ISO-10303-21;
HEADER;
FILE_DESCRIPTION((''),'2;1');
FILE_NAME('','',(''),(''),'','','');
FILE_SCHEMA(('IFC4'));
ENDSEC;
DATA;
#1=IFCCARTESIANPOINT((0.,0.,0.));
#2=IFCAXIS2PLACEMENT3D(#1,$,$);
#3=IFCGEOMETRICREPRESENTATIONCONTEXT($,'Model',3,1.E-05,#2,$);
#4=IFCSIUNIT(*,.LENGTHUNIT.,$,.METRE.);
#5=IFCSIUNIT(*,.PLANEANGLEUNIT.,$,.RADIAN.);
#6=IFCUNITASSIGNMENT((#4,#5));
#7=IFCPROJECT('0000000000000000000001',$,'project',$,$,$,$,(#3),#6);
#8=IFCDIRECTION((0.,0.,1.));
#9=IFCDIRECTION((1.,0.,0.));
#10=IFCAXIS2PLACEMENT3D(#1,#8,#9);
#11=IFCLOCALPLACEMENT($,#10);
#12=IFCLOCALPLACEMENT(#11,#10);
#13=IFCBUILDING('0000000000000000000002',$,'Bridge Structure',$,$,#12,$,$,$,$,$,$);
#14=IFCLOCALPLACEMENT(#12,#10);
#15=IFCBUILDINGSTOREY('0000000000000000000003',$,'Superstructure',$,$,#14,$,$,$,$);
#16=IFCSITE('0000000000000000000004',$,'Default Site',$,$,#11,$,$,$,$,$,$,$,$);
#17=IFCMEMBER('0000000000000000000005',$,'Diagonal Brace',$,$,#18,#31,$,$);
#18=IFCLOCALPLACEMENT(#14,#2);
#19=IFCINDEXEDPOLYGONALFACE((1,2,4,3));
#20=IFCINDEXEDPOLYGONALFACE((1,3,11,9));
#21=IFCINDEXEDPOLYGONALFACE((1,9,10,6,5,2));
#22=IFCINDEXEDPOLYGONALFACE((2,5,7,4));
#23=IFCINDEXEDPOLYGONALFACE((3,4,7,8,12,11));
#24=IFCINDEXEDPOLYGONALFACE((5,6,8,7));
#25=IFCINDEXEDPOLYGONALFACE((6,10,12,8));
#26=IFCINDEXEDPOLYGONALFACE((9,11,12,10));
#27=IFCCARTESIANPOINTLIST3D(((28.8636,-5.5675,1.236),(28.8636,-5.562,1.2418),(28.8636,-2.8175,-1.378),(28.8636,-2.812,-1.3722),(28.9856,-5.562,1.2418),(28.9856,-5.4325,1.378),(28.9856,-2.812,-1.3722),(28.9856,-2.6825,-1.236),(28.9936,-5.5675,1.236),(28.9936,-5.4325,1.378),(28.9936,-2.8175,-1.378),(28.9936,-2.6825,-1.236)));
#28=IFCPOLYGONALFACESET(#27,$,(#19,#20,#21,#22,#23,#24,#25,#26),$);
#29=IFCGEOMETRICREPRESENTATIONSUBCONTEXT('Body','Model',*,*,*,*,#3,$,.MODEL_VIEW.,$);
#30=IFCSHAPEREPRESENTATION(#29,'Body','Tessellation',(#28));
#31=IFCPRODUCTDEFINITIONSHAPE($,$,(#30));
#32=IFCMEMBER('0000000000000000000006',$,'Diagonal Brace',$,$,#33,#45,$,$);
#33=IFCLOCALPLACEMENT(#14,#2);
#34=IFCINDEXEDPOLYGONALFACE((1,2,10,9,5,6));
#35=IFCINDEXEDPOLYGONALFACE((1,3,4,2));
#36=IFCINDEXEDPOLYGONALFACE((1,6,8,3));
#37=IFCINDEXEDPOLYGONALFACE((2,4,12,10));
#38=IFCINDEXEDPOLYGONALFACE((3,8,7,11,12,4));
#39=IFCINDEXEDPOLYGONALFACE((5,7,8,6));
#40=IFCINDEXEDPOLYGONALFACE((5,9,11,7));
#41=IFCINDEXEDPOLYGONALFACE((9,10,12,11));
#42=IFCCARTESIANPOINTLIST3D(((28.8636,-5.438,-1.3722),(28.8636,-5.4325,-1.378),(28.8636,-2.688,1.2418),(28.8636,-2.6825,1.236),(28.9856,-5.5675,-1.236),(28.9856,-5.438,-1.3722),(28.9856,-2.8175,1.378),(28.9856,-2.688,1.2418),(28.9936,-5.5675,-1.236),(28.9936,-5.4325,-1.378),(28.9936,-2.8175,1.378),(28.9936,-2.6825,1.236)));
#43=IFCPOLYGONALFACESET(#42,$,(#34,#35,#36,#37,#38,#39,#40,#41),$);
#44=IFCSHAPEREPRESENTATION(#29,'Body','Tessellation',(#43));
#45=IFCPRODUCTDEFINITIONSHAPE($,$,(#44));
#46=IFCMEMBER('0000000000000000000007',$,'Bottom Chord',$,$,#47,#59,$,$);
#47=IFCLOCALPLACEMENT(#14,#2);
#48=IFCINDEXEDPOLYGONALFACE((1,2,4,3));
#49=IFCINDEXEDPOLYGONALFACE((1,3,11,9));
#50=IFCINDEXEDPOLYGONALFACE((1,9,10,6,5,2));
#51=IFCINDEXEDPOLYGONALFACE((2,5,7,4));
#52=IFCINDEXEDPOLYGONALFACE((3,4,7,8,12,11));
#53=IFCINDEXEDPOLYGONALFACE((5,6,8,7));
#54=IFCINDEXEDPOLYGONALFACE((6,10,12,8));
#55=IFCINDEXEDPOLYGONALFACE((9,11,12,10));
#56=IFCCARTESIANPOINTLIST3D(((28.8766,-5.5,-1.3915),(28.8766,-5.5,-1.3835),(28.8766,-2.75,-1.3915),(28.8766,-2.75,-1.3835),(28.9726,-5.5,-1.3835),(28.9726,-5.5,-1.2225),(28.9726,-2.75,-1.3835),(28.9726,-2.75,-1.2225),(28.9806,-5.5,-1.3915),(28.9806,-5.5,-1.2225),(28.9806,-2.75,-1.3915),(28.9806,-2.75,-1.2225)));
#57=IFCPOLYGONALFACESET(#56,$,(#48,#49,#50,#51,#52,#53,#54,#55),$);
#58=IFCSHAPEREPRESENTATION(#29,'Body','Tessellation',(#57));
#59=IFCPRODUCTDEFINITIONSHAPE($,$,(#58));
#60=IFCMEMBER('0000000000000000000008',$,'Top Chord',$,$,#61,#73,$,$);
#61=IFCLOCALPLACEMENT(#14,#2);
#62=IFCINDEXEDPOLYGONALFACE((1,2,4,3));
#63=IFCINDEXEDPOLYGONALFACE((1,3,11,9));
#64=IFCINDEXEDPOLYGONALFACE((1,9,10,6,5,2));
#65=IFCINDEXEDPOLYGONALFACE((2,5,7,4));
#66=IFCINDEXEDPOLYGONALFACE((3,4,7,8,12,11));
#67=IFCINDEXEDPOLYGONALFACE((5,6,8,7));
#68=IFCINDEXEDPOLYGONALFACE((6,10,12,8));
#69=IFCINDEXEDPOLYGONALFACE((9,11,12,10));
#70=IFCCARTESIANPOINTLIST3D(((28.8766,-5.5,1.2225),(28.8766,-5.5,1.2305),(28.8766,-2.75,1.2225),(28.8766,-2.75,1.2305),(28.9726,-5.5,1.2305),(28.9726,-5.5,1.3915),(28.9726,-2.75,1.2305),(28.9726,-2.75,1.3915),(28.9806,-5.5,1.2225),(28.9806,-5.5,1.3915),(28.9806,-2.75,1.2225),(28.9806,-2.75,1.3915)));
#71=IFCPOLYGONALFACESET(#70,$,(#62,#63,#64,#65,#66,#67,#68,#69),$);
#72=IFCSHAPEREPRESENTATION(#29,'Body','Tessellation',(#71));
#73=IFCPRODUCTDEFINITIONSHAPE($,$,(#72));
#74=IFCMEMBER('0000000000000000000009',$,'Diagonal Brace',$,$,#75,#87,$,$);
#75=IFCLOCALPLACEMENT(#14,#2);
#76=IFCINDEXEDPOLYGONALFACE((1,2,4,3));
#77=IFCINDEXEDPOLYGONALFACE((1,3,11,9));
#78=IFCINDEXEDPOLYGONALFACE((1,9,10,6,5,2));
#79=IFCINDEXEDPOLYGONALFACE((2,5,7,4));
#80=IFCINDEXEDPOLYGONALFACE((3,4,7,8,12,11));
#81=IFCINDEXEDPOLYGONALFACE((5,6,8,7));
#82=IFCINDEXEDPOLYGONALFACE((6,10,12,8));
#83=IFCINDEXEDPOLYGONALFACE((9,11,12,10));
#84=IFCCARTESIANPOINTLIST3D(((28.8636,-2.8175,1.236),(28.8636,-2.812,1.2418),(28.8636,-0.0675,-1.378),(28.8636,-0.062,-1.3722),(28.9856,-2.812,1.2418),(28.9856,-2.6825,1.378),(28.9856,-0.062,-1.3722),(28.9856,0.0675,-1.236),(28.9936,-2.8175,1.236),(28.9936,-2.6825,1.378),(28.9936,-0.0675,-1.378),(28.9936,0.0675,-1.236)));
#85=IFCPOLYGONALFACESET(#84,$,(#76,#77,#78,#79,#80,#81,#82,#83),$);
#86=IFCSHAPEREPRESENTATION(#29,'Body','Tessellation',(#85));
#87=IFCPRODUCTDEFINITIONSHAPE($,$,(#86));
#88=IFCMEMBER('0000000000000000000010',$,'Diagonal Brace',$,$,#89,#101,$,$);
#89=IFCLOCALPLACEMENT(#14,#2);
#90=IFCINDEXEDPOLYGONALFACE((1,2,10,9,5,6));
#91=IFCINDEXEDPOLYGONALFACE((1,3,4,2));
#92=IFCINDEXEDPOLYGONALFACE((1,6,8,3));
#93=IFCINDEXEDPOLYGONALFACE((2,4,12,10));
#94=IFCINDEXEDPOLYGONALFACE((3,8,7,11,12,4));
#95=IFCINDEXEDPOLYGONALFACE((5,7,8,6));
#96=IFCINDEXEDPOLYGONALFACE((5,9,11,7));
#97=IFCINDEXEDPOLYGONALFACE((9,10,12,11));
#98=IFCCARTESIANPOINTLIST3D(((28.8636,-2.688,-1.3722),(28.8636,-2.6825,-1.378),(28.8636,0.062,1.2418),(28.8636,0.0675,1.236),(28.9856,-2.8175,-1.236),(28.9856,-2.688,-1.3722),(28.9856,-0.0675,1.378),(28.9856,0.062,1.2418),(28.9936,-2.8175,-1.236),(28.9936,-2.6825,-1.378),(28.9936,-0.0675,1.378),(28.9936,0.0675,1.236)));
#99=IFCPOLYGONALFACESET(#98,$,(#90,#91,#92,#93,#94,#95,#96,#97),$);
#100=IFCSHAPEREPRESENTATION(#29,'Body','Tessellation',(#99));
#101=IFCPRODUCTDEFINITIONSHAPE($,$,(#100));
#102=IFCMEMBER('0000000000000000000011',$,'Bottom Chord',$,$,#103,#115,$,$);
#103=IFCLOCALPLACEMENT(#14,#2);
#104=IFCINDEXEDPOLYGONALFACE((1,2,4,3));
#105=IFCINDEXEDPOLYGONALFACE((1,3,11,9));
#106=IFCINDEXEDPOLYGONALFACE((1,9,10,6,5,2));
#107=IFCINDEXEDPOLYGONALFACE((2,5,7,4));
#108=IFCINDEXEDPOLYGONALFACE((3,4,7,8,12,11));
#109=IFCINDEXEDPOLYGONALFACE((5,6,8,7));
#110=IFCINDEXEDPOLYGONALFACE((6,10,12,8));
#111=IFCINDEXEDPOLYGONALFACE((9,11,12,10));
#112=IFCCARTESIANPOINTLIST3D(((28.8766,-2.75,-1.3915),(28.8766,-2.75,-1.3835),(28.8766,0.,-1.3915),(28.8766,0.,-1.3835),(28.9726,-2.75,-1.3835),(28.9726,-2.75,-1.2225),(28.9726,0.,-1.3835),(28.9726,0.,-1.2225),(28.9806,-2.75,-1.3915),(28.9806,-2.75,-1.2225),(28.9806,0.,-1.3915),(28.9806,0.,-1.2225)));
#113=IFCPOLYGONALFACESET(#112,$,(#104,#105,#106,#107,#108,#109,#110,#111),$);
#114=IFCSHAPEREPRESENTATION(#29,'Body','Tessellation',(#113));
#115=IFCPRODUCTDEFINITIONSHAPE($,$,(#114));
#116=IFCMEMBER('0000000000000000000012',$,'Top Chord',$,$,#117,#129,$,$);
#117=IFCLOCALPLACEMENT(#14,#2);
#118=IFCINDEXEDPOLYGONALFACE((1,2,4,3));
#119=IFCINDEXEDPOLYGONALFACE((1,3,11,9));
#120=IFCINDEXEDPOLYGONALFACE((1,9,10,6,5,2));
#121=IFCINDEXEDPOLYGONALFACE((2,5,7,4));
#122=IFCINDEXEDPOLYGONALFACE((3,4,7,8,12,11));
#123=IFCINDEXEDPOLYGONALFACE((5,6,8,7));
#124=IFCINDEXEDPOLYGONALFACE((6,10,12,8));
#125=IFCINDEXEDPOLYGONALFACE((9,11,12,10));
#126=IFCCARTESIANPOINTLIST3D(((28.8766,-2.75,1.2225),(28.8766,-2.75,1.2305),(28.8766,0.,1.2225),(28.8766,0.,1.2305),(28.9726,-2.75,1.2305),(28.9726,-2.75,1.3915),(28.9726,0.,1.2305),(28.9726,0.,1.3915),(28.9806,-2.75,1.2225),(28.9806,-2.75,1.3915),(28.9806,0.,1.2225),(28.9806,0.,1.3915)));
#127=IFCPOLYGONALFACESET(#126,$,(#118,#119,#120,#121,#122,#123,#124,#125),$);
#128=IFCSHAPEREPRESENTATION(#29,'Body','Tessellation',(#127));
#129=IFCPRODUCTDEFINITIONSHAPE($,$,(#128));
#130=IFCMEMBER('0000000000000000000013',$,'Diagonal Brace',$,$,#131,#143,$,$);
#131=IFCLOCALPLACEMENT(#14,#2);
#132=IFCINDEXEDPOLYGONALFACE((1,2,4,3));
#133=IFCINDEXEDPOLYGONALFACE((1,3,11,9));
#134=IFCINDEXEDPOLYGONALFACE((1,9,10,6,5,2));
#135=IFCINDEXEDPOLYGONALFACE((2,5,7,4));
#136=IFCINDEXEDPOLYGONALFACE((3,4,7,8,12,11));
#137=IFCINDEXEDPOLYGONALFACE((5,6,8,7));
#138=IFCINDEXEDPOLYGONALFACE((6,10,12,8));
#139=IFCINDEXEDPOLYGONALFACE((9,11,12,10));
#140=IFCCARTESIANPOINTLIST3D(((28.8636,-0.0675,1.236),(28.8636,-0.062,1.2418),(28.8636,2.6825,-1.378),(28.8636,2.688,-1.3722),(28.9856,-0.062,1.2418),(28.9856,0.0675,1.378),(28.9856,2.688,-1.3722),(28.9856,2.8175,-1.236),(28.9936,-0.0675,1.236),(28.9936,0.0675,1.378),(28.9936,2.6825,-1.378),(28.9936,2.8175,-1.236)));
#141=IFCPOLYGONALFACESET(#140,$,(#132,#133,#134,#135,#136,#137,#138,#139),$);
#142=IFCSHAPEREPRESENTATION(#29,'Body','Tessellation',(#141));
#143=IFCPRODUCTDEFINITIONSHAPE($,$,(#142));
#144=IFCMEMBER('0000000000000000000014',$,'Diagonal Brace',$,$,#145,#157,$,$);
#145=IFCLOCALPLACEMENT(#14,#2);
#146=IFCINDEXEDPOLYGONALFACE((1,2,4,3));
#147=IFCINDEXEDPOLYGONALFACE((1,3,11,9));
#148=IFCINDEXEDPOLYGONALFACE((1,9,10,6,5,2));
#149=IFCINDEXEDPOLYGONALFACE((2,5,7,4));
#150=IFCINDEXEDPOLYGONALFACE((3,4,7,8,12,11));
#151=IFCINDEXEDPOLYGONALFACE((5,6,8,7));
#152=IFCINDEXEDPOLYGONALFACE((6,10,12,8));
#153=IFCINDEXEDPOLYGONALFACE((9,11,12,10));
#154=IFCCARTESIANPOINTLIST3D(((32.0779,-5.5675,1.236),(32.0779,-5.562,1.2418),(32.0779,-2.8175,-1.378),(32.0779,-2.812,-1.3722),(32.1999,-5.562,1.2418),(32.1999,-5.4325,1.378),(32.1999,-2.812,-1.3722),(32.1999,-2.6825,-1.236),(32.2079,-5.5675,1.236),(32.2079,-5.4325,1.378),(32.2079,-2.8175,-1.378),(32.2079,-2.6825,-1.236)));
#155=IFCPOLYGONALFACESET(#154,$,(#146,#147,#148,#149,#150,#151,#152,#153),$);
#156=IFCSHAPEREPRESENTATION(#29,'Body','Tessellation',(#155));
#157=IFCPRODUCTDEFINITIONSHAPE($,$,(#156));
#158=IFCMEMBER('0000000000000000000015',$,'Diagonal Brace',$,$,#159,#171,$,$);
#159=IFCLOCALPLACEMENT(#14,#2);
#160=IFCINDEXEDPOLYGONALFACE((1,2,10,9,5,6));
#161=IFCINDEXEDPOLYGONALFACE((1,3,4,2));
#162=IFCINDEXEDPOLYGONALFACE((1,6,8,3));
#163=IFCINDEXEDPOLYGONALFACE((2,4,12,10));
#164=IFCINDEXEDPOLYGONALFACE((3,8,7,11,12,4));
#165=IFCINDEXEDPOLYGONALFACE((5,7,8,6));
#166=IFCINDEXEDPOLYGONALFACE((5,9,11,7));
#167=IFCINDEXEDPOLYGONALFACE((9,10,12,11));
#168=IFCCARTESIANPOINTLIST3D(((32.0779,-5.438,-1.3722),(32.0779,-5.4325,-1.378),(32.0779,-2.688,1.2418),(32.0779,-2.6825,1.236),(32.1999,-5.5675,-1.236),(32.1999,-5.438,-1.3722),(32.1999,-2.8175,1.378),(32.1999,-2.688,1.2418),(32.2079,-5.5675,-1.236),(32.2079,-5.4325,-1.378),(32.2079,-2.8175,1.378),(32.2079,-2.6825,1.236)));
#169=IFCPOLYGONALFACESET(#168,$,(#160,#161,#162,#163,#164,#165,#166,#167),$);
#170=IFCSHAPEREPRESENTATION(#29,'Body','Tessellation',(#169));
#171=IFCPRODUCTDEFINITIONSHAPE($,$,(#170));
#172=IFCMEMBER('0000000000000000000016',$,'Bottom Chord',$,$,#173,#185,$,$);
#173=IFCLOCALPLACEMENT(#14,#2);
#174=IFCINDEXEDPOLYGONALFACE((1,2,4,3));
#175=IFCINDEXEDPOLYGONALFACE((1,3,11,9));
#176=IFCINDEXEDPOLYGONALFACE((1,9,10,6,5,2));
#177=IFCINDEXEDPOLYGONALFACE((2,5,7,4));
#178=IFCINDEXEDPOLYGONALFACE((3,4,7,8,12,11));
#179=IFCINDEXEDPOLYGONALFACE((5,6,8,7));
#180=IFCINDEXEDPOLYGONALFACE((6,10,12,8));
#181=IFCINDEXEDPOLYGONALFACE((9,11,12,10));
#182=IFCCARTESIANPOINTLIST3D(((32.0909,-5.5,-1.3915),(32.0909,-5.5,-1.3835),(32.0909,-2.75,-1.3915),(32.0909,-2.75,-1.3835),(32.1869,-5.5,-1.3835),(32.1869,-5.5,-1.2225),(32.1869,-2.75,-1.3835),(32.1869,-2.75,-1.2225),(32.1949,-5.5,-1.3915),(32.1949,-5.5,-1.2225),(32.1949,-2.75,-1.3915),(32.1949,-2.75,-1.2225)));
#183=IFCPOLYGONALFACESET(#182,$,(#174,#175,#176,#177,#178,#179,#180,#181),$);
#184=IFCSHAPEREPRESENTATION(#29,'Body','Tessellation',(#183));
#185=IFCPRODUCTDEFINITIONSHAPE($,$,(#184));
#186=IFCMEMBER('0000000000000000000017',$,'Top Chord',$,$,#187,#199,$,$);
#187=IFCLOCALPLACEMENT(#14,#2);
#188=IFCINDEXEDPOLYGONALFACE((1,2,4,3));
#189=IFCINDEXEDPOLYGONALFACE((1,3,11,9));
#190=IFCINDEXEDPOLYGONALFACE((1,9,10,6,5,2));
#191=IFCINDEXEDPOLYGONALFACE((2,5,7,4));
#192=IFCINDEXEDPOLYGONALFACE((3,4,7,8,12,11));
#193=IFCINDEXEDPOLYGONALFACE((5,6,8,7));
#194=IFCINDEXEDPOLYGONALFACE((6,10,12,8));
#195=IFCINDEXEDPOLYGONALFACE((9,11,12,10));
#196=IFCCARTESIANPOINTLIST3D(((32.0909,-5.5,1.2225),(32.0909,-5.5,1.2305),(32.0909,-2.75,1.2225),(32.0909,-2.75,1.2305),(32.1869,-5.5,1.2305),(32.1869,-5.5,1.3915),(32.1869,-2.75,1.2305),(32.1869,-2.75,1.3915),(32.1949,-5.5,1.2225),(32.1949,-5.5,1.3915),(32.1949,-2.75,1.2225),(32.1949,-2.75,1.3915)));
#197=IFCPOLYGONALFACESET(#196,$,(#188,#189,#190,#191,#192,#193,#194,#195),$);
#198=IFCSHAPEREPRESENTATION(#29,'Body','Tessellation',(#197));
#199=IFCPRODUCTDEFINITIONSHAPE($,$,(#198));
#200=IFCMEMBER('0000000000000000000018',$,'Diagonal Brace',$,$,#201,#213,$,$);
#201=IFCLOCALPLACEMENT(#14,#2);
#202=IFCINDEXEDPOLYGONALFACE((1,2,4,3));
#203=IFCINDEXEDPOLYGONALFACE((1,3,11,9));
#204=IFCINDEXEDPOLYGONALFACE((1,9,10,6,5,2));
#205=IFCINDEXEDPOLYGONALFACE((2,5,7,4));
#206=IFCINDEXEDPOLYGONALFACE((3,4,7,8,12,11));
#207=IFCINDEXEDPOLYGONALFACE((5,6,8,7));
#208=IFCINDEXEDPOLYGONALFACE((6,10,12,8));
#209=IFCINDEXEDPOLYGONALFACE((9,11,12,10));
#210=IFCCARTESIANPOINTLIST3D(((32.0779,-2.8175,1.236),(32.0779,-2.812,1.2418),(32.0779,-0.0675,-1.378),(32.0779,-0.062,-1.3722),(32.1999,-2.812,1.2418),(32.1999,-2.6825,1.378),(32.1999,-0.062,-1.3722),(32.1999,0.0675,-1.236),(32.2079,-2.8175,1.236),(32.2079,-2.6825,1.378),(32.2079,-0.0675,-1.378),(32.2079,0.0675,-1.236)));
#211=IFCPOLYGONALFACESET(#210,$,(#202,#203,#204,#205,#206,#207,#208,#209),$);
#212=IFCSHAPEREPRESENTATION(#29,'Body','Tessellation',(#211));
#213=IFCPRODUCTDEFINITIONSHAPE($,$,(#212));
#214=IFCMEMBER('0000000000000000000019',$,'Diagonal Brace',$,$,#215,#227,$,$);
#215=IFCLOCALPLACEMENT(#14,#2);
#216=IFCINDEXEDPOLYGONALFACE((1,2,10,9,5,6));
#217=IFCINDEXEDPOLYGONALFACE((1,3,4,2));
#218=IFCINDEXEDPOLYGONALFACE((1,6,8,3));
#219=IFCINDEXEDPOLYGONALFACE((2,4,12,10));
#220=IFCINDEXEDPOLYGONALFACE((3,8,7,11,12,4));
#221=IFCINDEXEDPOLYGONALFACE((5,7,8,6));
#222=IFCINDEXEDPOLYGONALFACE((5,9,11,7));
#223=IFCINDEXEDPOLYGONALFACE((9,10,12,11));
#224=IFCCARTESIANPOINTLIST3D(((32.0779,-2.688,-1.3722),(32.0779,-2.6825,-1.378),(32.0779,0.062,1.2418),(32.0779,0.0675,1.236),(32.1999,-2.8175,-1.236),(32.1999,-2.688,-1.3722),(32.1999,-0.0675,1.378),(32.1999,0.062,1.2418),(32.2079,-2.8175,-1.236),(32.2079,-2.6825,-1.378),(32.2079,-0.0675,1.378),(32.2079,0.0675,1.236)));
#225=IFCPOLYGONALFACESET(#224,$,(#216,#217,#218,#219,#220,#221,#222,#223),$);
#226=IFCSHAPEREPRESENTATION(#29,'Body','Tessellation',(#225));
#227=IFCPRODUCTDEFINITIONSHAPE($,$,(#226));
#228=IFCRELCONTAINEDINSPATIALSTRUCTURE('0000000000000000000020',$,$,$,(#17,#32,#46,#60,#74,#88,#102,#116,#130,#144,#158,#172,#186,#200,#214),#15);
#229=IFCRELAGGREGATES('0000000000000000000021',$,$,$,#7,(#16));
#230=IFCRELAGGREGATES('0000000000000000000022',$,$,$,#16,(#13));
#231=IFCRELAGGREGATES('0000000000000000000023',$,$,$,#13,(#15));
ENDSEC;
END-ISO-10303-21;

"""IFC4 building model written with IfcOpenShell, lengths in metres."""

from ifc_helpers import new_model, si_unit, frame, origin, origin_with_axes, origin_2d_with_axis, place, context, subcontext, project, spatial, l_section, extrude, element, save


model = new_model("IFC4")

# Units and contexts
model_context = context("Model", 3, precision=1e-05, world=origin())
body_context = subcontext(model_context, "Body", "Model", "MODEL_VIEW")
ifc_project = project(units=[si_unit("LENGTHUNIT", "METRE"), si_unit("PLANEANGLEUNIT", "RADIAN")], contexts=[model_context])

# Site, building, storey
site_placement = place(None, origin_with_axes())
site = spatial("IfcSite", under=ifc_project, at=site_placement, Name="Default Site")
building_placement = place(site_placement, origin_with_axes())
building = spatial("IfcBuilding", under=site, at=building_placement, Name="Bridge Structure")
storey_placement = place(building_placement, origin_with_axes())
storey = spatial("IfcBuildingStorey", under=building, at=storey_placement, Name="Superstructure")

# Members
for number, where, z_axis, x_axis, name in (
    (1, (28.9286, -5.5, 1.307), (0.0, 0.724802, -0.688957), (-1.0, 0.0, 0.0), "Diagonal Brace"),
    (2, (28.9286, -5.5, -1.307), (0.0, 0.724802, 0.688957), (-1.0, 0.0, 0.0), "Diagonal Brace"),
):
    element("IfcMember", number, at=place(storey_placement, frame(where, z_axis=z_axis, x_axis=x_axis)), inside=storey, Name=name, context=body_context, shape_type="SweptSolid", body=[
        extrude(l_section(Depth=0.196, Width=0.13, Thickness=0.008, at=origin_2d_with_axis()), origin_with_axes(), (0.0, 0.0, 1.0), 3.7941),
    ])
for number, where, z_axis, x_axis, name in (
    (3, (28.9286, -5.5, -1.307), (0.0, 1.0, 0.0), (-1.0, 0.0, 0.0), "Bottom Chord"),
    (4, (28.9286, -5.5, 1.307), (0.0, 1.0, 0.0), (-1.0, 0.0, 0.0), "Top Chord"),
):
    element("IfcMember", number, at=place(storey_placement, frame(where, z_axis=z_axis, x_axis=x_axis)), inside=storey, Name=name, context=body_context, shape_type="SweptSolid", body=[
        extrude(l_section(Depth=0.169, Width=0.104, Thickness=0.008, at=origin_2d_with_axis()), origin_with_axes(), (0.0, 0.0, 1.0), 2.75),
    ])
for number, where, z_axis, x_axis, name in (
    (5, (28.9286, -2.75, 1.307), (0.0, 0.724802, -0.688957), (-1.0, 0.0, 0.0), "Diagonal Brace"),
    (6, (28.9286, -2.75, -1.307), (0.0, 0.724802, 0.688957), (-1.0, 0.0, 0.0), "Diagonal Brace"),
):
    element("IfcMember", number, at=place(storey_placement, frame(where, z_axis=z_axis, x_axis=x_axis)), inside=storey, Name=name, context=body_context, shape_type="SweptSolid", body=[
        extrude(l_section(Depth=0.196, Width=0.13, Thickness=0.008, at=origin_2d_with_axis()), origin_with_axes(), (0.0, 0.0, 1.0), 3.7941),
    ])
for number, where, z_axis, x_axis, name in (
    (7, (28.9286, -2.75, -1.307), (0.0, 1.0, 0.0), (-1.0, 0.0, 0.0), "Bottom Chord"),
    (8, (28.9286, -2.75, 1.307), (0.0, 1.0, 0.0), (-1.0, 0.0, 0.0), "Top Chord"),
):
    element("IfcMember", number, at=place(storey_placement, frame(where, z_axis=z_axis, x_axis=x_axis)), inside=storey, Name=name, context=body_context, shape_type="SweptSolid", body=[
        extrude(l_section(Depth=0.169, Width=0.104, Thickness=0.008, at=origin_2d_with_axis()), origin_with_axes(), (0.0, 0.0, 1.0), 2.75),
    ])
for number, where, z_axis, x_axis, name in (
    (9, (28.9286, 0.0, 1.307), (0.0, 0.724802, -0.688957), (-1.0, 0.0, 0.0), "Diagonal Brace"),
    (10, (32.1429, -5.5, 1.307), (0.0, 0.724802, -0.688957), (-1.0, 0.0, 0.0), "Diagonal Brace"),
    (11, (32.1429, -5.5, -1.307), (0.0, 0.724802, 0.688957), (-1.0, 0.0, 0.0), "Diagonal Brace"),
):
    element("IfcMember", number, at=place(storey_placement, frame(where, z_axis=z_axis, x_axis=x_axis)), inside=storey, Name=name, context=body_context, shape_type="SweptSolid", body=[
        extrude(l_section(Depth=0.196, Width=0.13, Thickness=0.008, at=origin_2d_with_axis()), origin_with_axes(), (0.0, 0.0, 1.0), 3.7941),
    ])
for number, where, z_axis, x_axis, name in (
    (12, (32.1429, -5.5, -1.307), (0.0, 1.0, 0.0), (-1.0, 0.0, 0.0), "Bottom Chord"),
    (13, (32.1429, -5.5, 1.307), (0.0, 1.0, 0.0), (-1.0, 0.0, 0.0), "Top Chord"),
):
    element("IfcMember", number, at=place(storey_placement, frame(where, z_axis=z_axis, x_axis=x_axis)), inside=storey, Name=name, context=body_context, shape_type="SweptSolid", body=[
        extrude(l_section(Depth=0.169, Width=0.104, Thickness=0.008, at=origin_2d_with_axis()), origin_with_axes(), (0.0, 0.0, 1.0), 2.75),
    ])
for number, where, z_axis, x_axis, name in (
    (14, (32.1429, -2.75, 1.307), (0.0, 0.724802, -0.688957), (-1.0, 0.0, 0.0), "Diagonal Brace"),
    (15, (32.1429, -2.75, -1.307), (0.0, 0.724802, 0.688957), (-1.0, 0.0, 0.0), "Diagonal Brace"),
):
    element("IfcMember", number, at=place(storey_placement, frame(where, z_axis=z_axis, x_axis=x_axis)), inside=storey, Name=name, context=body_context, shape_type="SweptSolid", body=[
        extrude(l_section(Depth=0.196, Width=0.13, Thickness=0.008, at=origin_2d_with_axis()), origin_with_axes(), (0.0, 0.0, 1.0), 3.7941),
    ])

save(model, "model.ifc")
